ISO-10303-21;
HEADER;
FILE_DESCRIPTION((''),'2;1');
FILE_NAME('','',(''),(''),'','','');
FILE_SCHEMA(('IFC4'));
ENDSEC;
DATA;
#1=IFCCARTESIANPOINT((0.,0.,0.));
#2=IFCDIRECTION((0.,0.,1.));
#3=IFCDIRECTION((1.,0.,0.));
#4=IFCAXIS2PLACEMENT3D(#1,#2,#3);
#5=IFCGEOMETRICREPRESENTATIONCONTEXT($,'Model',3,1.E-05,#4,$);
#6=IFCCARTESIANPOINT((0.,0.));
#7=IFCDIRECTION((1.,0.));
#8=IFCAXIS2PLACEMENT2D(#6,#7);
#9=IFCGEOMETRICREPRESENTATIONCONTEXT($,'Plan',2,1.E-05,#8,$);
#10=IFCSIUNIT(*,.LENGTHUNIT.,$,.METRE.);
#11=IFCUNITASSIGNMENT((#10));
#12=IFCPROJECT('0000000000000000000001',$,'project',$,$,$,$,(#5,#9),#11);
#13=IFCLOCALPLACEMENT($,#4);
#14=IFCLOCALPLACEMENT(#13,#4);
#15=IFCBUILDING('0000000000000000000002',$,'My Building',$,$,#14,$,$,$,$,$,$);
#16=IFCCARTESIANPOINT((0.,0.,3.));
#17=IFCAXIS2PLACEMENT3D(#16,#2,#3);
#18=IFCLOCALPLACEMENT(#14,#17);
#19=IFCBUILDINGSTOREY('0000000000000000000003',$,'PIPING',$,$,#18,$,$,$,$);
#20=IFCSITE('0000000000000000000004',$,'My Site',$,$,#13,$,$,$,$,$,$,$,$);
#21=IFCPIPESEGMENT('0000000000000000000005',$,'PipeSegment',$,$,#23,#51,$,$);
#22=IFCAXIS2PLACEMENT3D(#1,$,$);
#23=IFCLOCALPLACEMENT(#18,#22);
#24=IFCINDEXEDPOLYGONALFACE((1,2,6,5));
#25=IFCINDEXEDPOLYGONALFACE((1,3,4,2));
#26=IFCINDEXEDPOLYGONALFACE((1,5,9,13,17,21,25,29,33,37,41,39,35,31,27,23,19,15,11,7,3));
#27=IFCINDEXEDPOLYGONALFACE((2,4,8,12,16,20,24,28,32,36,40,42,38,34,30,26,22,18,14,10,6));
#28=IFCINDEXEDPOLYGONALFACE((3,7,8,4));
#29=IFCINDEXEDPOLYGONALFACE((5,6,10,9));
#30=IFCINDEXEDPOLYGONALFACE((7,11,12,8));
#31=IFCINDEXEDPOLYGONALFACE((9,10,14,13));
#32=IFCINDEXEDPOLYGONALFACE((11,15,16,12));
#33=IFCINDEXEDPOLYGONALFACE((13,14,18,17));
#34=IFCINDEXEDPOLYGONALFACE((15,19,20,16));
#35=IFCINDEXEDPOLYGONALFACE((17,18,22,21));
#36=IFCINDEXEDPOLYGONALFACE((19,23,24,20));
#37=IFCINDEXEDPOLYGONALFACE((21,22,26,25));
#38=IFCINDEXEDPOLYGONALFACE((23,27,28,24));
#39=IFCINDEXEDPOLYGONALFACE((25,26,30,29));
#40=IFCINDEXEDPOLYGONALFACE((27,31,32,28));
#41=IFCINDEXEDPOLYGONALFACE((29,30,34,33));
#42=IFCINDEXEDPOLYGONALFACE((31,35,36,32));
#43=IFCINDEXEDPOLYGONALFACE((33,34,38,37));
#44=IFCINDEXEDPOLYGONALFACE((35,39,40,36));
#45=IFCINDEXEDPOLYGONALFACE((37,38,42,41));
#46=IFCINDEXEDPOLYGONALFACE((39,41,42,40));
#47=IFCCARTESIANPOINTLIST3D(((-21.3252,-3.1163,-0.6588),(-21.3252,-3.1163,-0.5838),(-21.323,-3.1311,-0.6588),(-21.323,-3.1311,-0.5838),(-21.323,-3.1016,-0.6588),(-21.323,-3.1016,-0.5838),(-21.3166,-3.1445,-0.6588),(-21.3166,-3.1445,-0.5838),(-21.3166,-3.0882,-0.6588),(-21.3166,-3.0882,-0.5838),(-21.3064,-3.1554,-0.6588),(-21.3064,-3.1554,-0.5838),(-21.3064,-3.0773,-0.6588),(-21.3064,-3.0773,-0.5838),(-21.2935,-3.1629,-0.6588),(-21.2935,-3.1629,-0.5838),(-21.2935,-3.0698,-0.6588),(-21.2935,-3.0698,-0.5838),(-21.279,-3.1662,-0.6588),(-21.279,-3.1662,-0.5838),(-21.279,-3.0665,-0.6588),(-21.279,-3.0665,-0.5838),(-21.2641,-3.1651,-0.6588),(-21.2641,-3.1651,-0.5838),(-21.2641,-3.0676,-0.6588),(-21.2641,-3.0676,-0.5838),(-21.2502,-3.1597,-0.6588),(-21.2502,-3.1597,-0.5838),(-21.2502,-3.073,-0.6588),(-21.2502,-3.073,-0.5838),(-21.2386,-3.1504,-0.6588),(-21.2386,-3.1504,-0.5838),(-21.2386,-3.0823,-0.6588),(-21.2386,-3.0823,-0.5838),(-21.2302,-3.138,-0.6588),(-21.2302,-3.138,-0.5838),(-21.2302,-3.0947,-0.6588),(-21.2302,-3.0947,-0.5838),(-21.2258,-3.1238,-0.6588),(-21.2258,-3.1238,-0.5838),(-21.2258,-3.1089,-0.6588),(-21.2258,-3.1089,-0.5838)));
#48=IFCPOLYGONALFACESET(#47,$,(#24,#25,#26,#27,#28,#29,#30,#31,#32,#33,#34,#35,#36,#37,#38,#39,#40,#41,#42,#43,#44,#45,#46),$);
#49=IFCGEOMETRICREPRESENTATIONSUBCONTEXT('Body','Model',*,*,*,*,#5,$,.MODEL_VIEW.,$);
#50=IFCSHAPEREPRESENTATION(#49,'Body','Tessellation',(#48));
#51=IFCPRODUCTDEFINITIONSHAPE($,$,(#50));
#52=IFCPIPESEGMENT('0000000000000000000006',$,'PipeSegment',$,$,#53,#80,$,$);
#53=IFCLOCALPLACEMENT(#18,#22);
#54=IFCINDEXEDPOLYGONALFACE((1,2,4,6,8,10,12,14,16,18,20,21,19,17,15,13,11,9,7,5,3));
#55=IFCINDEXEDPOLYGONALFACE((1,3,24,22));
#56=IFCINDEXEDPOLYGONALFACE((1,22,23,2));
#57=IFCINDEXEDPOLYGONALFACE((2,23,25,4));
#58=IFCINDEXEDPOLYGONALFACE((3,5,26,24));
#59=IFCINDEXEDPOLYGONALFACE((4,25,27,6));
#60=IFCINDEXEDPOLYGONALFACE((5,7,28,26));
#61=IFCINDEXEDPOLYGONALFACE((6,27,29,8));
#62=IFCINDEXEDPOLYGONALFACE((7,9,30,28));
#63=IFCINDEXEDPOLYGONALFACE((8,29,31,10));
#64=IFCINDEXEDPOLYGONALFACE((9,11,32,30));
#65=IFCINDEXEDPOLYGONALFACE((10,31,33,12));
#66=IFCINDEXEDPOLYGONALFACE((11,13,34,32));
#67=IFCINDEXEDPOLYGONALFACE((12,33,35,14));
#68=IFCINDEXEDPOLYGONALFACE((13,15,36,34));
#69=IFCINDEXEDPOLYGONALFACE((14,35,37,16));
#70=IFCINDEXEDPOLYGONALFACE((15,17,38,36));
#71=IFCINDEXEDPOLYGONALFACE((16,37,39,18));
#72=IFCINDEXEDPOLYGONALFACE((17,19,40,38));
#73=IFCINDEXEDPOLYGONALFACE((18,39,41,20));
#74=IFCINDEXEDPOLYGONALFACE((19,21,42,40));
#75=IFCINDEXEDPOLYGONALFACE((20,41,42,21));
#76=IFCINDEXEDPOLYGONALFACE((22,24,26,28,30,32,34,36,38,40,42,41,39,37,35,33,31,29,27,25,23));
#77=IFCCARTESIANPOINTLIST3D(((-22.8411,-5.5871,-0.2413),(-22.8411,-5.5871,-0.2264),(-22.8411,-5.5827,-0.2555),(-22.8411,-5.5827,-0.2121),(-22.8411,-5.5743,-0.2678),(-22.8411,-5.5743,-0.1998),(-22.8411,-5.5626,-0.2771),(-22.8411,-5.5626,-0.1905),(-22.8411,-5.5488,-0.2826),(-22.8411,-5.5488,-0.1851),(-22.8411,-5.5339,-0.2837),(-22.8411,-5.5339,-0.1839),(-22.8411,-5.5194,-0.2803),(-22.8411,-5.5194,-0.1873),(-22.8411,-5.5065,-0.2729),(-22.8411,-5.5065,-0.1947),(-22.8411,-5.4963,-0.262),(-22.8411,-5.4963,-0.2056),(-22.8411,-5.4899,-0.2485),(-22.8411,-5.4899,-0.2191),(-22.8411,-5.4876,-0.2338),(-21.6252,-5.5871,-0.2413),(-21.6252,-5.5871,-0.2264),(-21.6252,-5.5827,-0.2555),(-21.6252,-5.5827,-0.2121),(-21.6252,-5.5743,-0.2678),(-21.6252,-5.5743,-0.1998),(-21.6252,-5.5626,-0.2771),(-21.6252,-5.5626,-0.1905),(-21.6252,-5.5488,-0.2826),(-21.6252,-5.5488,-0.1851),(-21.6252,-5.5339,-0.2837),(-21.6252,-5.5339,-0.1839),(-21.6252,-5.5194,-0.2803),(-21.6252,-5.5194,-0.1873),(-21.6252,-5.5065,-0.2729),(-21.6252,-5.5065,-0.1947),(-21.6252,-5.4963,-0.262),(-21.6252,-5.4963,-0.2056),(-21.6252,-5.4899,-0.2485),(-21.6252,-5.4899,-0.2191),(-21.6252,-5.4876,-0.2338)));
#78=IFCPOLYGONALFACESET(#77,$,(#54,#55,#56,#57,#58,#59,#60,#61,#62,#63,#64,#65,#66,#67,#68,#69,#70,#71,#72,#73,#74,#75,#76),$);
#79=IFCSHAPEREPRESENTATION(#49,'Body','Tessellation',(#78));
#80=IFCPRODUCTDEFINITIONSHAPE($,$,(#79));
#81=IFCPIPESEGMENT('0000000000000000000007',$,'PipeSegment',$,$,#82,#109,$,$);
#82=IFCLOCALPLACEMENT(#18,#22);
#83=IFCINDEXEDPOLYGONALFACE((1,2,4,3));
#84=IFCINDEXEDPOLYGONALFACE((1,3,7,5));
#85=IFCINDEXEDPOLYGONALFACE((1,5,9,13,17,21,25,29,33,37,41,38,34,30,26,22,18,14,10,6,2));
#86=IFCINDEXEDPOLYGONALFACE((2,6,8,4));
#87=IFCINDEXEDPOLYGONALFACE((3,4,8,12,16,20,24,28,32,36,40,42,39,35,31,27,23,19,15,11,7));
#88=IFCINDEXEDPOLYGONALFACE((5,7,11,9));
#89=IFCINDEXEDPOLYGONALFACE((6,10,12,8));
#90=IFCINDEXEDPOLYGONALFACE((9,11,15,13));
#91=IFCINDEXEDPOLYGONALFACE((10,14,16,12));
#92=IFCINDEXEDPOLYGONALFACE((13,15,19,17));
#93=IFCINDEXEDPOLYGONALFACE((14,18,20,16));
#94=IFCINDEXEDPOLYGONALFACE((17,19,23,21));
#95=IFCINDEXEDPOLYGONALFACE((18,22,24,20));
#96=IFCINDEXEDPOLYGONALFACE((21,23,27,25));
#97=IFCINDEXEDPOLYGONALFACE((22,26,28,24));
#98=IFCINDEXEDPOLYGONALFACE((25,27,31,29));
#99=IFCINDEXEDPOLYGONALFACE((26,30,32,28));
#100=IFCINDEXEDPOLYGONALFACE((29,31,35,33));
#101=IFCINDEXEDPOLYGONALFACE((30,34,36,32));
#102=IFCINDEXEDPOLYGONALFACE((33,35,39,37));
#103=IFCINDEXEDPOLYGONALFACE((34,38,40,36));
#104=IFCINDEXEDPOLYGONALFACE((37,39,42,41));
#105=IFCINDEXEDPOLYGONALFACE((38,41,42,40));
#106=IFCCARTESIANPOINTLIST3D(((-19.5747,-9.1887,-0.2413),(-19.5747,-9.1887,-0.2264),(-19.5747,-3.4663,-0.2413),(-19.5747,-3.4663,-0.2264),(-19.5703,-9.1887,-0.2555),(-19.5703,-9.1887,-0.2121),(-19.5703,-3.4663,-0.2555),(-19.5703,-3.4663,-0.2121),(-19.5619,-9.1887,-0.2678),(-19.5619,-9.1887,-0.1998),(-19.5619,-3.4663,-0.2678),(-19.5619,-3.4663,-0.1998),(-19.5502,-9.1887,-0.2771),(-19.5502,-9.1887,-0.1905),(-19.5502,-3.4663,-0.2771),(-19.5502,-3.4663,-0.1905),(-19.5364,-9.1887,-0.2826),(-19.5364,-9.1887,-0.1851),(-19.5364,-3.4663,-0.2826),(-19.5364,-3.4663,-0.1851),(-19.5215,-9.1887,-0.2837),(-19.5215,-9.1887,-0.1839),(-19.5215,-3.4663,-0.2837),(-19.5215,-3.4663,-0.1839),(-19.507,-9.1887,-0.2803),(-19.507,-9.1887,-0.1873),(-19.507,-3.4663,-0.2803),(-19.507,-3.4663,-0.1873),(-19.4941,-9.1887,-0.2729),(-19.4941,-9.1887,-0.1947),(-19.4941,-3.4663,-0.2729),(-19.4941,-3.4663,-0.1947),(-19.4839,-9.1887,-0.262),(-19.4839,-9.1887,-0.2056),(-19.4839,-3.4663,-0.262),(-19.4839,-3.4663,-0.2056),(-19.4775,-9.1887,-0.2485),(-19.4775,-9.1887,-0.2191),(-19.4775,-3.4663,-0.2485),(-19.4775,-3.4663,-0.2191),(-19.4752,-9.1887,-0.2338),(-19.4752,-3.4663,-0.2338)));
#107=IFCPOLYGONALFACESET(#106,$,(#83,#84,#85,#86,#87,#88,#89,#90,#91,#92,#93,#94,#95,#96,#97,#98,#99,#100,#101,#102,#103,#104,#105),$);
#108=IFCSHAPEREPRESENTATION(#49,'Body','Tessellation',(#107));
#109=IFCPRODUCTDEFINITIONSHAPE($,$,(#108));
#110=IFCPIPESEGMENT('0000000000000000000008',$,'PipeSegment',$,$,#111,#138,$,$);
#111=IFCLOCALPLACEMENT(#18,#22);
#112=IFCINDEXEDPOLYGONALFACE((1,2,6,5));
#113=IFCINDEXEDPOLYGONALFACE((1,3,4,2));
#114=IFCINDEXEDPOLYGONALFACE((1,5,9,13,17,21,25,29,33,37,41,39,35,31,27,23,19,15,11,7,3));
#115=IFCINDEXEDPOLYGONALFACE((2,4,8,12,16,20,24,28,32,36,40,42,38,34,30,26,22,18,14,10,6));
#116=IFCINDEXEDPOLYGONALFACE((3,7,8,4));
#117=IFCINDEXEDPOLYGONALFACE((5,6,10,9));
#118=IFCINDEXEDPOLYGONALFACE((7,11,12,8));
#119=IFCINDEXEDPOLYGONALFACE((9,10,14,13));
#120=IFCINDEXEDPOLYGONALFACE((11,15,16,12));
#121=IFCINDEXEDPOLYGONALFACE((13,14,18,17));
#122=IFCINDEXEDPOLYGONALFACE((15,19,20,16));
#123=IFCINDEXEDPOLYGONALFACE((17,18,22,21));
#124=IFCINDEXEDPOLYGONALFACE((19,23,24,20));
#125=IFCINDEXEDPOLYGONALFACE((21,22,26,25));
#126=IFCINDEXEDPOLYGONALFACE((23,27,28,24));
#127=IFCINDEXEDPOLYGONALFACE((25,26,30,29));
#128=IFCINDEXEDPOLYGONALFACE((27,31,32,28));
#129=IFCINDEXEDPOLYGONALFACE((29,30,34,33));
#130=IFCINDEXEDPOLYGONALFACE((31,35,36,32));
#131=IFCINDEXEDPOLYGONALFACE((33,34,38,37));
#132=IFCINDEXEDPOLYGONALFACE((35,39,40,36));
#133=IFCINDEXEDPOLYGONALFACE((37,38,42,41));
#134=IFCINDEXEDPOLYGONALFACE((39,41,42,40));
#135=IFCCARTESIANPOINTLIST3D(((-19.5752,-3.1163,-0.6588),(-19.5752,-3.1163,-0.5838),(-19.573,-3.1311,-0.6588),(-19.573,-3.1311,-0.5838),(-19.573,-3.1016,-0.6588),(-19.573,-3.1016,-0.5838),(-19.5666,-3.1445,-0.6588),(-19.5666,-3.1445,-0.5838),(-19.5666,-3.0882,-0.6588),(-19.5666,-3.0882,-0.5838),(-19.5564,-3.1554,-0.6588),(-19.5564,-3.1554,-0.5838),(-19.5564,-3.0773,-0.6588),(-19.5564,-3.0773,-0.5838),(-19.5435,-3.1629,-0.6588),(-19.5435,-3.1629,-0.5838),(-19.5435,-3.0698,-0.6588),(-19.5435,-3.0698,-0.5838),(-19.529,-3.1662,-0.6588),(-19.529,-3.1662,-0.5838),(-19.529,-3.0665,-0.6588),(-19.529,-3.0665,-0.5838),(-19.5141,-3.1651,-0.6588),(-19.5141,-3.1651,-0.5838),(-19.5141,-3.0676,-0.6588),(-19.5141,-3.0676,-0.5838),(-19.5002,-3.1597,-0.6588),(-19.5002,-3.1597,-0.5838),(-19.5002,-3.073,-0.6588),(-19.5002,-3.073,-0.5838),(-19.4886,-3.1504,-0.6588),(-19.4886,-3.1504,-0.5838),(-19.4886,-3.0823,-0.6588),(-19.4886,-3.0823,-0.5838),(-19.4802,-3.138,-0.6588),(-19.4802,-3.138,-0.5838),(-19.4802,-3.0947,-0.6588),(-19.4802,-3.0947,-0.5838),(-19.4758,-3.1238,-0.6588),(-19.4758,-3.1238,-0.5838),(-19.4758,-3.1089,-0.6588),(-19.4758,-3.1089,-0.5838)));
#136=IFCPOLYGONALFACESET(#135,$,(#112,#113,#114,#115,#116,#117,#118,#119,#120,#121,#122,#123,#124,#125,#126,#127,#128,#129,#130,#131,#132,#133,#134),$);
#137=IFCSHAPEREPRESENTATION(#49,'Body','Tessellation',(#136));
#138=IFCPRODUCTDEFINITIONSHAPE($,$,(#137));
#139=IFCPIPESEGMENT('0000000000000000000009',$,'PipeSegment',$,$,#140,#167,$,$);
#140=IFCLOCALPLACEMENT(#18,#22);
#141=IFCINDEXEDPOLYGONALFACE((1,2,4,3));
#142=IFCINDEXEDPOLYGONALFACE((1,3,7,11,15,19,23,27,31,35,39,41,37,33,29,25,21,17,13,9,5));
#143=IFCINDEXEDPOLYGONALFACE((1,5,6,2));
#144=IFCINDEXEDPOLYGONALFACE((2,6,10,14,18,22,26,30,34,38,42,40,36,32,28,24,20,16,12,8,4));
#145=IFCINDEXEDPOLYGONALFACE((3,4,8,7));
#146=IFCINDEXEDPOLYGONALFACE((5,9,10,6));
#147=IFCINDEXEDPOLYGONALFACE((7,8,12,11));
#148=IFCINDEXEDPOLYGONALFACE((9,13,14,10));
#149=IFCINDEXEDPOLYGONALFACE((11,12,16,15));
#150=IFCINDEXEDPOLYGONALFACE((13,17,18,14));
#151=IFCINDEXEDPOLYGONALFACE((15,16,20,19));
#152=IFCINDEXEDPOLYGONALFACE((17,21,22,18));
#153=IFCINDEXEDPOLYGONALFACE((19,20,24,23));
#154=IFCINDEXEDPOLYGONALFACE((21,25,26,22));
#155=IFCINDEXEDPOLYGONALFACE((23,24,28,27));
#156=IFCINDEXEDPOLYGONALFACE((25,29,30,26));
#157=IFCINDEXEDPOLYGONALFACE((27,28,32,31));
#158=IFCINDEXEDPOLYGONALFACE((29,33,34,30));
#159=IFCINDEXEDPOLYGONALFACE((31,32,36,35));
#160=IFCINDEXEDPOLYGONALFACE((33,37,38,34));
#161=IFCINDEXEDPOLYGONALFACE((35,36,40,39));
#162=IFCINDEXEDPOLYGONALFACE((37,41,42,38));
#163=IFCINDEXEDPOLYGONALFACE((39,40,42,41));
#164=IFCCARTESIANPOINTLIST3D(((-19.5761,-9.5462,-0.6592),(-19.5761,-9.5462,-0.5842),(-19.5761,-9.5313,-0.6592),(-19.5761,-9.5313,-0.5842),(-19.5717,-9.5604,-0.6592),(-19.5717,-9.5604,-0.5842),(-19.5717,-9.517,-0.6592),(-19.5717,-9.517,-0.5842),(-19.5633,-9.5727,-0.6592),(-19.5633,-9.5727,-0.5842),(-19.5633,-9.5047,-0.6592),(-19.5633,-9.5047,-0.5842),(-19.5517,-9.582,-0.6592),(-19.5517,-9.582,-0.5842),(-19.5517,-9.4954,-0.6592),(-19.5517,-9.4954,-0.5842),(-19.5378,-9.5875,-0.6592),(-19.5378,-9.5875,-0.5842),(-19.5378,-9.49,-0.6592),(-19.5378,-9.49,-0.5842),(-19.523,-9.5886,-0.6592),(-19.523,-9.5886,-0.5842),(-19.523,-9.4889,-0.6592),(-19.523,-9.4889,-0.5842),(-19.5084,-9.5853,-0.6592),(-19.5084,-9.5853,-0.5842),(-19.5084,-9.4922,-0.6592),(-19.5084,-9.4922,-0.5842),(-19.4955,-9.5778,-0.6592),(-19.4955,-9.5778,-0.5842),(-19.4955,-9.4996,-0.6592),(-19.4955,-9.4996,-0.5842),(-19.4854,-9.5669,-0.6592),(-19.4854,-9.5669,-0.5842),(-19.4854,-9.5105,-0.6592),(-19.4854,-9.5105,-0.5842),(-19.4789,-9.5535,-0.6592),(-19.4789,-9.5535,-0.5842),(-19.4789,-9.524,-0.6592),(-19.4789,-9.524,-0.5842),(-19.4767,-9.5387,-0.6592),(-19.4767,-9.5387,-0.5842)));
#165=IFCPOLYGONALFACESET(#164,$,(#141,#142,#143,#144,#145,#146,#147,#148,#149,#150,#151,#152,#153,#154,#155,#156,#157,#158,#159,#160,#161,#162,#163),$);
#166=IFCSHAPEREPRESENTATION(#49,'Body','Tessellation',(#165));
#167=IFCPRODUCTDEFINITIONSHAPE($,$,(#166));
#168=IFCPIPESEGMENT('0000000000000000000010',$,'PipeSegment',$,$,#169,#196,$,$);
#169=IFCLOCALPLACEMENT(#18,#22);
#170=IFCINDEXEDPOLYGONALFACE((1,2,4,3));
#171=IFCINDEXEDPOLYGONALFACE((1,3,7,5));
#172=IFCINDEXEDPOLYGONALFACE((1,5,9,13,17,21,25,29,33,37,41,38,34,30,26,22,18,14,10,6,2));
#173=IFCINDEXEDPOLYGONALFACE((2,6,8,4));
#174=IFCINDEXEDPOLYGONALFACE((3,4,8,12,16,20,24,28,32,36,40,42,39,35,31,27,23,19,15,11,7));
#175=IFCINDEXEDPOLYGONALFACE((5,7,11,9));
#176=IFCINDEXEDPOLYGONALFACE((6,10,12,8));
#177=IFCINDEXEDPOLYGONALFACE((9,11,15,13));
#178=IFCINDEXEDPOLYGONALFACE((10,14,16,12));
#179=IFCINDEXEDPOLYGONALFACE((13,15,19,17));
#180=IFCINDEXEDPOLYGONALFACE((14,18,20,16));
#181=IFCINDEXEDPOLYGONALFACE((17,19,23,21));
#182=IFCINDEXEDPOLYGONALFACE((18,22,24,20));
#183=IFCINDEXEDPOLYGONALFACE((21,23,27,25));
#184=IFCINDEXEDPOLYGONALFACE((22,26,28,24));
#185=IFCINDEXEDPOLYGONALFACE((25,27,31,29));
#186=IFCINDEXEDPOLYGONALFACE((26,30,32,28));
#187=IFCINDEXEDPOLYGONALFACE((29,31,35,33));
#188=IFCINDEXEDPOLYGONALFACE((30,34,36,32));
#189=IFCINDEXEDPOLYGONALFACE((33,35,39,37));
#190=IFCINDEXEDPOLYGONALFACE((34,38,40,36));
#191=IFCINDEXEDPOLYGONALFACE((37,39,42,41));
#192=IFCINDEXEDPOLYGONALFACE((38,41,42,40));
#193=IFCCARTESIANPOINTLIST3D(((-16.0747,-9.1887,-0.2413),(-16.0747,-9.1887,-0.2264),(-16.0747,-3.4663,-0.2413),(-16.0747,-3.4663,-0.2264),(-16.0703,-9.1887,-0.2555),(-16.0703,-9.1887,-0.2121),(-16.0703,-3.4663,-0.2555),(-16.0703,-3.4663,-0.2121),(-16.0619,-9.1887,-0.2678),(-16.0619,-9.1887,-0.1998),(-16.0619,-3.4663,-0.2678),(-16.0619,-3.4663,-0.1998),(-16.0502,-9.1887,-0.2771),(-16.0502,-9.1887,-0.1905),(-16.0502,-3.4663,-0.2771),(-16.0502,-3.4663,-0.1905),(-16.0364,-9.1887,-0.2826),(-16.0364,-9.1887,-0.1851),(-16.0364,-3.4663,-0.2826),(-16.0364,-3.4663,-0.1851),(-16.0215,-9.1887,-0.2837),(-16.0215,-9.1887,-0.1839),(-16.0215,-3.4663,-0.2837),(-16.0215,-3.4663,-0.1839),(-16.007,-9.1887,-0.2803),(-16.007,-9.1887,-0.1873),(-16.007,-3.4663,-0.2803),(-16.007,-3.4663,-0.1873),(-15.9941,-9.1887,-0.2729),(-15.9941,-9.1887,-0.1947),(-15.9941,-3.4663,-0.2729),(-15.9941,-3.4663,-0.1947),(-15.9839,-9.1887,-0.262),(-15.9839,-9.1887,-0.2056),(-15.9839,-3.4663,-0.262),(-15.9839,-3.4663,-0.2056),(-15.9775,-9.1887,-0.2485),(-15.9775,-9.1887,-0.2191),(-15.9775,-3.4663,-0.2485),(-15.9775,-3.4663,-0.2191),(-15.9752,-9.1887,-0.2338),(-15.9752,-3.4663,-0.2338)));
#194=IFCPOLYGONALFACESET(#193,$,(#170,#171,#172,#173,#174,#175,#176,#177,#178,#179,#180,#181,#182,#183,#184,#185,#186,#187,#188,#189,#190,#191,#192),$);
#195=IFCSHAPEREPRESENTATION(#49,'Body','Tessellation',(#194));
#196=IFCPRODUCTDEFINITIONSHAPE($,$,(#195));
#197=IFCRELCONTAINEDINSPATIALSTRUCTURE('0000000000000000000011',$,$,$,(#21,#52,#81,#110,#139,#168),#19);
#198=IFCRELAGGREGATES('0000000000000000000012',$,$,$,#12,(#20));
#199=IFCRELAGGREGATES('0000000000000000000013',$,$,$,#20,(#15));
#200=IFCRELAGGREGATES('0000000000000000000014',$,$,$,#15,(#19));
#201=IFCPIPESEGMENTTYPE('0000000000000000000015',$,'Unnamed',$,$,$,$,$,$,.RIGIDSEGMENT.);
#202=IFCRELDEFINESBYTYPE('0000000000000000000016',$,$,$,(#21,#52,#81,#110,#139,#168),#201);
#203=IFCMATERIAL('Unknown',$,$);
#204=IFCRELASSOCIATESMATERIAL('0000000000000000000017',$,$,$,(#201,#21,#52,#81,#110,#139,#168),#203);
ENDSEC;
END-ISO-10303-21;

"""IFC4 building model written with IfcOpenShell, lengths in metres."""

from ifc_helpers import new_model, si_unit, frame, origin_with_axes, origin_2d_with_axis, place, context, subcontext, project, spatial, circle, extrude, material, material_profile, profile_set, profile_usage, type_object, element, save


model = new_model("IFC4")

# Units and contexts
model_context = context("Model", 3, precision=1e-05, world=origin_with_axes())
plan_context = context("Plan", 2, precision=1e-05, world=origin_2d_with_axis())
body_context = subcontext(model_context, "Body", "Model", "MODEL_VIEW")
ifc_project = project(units=[si_unit("LENGTHUNIT", "METRE")], contexts=[model_context, plan_context])

# Site, building, storey
site_placement = place(None, origin_with_axes())
site = spatial("IfcSite", under=ifc_project, at=site_placement, Name="My Site")
building_placement = place(site_placement, origin_with_axes())
building = spatial("IfcBuilding", under=site, at=building_placement, Name="My Building")
storey_placement = place(building_placement, frame((0.0, 0.0, 3.0), z_axis=(0.0, 0.0, 1.0), x_axis=(1.0, 0.0, 0.0)))
storey = spatial("IfcBuildingStorey", under=building, at=storey_placement, Name="PIPING")

# Pipe segments
ifc_material = material(Name="Unknown")
ifc_material_profile = material_profile(ifc_material, circle(Radius=0.05))
ifc_profile_set = profile_set([ifc_material_profile])
pipe_segment_type = type_object("IfcPipeSegmentType", Name="Unnamed", PredefinedType="RIGIDSEGMENT", material=ifc_profile_set)
ifc_profile_usage_1 = profile_usage(ifc_profile_set, cardinal=5)
pipe_segment_1_placement = place(storey_placement, frame((-21.2752, -3.1163, -0.5838), z_axis=(0.0, 0.0, -1.0), x_axis=(-1.0, 0.0, 0.0)))
element("IfcPipeSegment", 1, at=pipe_segment_1_placement, inside=storey, type_object=pipe_segment_type, material=ifc_profile_usage_1, Name="PipeSegment", context=body_context, shape_type="SweptSolid", body=[
    extrude(circle(Radius=0.05), origin_with_axes(), (0.0, 0.0, 1.0), 0.075),
])
ifc_profile_usage_2 = profile_usage(ifc_profile_set, cardinal=5)
pipe_segment_2_placement = place(storey_placement, frame((-22.8411, -5.5376, -0.2338), z_axis=(1.0, 0.0, 0.0), x_axis=(0.0, 1.0, 0.0)))
element("IfcPipeSegment", 2, at=pipe_segment_2_placement, inside=storey, type_object=pipe_segment_type, material=ifc_profile_usage_2, Name="PipeSegment", context=body_context, shape_type="SweptSolid", body=[
    extrude(circle(Radius=0.05), origin_with_axes(), (0.0, 0.0, 1.0), 1.2159),
])
ifc_profile_usage_3 = profile_usage(ifc_profile_set, cardinal=5)
pipe_segment_3_placement = place(storey_placement, frame((-19.5252, -3.4663, -0.2338), z_axis=(0.0, -1.0, 0.0), x_axis=(1.0, 0.0, 0.0)))
element("IfcPipeSegment", 3, at=pipe_segment_3_placement, inside=storey, type_object=pipe_segment_type, material=ifc_profile_usage_3, Name="PipeSegment", context=body_context, shape_type="SweptSolid", body=[
    extrude(circle(Radius=0.05), origin_with_axes(), (0.0, 0.0, 1.0), 5.7224),
])
ifc_profile_usage_4 = profile_usage(ifc_profile_set, cardinal=5)
pipe_segment_4_placement = place(storey_placement, frame((-19.5252, -3.1163, -0.5838), z_axis=(0.0, 0.0, -1.0), x_axis=(-1.0, 0.0, 0.0)))
element("IfcPipeSegment", 4, at=pipe_segment_4_placement, inside=storey, type_object=pipe_segment_type, material=ifc_profile_usage_4, Name="PipeSegment", context=body_context, shape_type="SweptSolid", body=[
    extrude(circle(Radius=0.05), origin_with_axes(), (0.0, 0.0, 1.0), 0.075),
])
ifc_profile_usage_5 = profile_usage(ifc_profile_set, cardinal=5)
pipe_segment_5_placement = place(storey_placement, frame((-19.5267, -9.5387, -0.5842), z_axis=(0.0, 0.0, -1.0), x_axis=(1.0, 0.0, 0.0)))
element("IfcPipeSegment", 5, at=pipe_segment_5_placement, inside=storey, type_object=pipe_segment_type, material=ifc_profile_usage_5, Name="PipeSegment", context=body_context, shape_type="SweptSolid", body=[
    extrude(circle(Radius=0.05), origin_with_axes(), (0.0, 0.0, 1.0), 0.075),
])
ifc_profile_usage_6 = profile_usage(ifc_profile_set, cardinal=5)
pipe_segment_6_placement = place(storey_placement, frame((-16.0252, -3.4663, -0.2338), z_axis=(0.0, -1.0, 0.0), x_axis=(1.0, 0.0, 0.0)))
element("IfcPipeSegment", 6, at=pipe_segment_6_placement, inside=storey, type_object=pipe_segment_type, material=ifc_profile_usage_6, Name="PipeSegment", context=body_context, shape_type="SweptSolid", body=[
    extrude(circle(Radius=0.05), origin_with_axes(), (0.0, 0.0, 1.0), 5.7224),
])

save(model, "model.ifc")
